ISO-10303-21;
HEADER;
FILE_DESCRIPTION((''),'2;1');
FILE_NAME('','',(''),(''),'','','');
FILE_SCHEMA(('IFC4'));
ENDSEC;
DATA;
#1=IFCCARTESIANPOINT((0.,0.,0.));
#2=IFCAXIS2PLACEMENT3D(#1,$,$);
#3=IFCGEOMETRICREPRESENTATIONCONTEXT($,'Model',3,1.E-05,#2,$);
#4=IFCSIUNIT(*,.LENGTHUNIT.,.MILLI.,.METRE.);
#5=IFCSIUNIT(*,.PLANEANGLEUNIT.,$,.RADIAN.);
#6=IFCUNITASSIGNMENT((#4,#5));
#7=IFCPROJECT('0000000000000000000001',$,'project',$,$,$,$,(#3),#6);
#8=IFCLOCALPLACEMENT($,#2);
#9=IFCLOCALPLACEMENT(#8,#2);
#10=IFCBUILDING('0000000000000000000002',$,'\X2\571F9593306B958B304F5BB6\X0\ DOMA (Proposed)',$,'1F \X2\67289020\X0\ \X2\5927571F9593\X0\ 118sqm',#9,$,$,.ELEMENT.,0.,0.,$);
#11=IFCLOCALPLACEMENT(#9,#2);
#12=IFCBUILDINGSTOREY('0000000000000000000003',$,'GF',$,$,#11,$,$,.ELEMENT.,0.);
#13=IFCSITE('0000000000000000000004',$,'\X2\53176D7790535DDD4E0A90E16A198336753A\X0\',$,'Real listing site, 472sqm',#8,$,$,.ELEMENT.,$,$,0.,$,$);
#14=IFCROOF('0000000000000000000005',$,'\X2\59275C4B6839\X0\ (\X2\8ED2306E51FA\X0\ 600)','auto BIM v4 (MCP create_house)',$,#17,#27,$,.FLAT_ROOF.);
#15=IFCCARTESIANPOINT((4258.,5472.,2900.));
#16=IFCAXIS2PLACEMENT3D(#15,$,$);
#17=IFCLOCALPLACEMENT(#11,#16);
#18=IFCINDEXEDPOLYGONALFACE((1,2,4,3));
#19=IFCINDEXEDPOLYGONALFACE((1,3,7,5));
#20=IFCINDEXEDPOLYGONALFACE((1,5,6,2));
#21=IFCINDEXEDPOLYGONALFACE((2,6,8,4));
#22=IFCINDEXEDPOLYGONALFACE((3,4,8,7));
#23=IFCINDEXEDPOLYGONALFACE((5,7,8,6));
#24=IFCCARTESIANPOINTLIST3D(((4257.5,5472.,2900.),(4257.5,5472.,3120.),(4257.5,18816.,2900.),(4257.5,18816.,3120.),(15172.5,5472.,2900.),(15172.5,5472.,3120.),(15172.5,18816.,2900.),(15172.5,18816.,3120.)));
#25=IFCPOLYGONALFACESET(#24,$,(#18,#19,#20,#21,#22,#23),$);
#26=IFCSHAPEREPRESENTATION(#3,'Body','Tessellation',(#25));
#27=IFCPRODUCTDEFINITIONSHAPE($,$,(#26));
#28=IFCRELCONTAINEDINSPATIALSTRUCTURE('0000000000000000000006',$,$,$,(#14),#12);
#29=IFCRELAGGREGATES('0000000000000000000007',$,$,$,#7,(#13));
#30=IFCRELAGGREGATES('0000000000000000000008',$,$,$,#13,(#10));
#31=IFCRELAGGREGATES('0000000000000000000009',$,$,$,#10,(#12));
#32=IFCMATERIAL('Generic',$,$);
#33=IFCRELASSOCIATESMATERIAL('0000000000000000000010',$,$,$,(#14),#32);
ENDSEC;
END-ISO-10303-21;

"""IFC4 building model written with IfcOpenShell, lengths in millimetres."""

from ifc_helpers import new_model, si_unit, frame, frame_2d, origin, place, context, project, spatial, rectangle, extrude, material, element, save


model = new_model("IFC4")

# Units and contexts
model_context = context("Model", 3, precision=1e-05, world=origin())
ifc_project = project(units=[si_unit("LENGTHUNIT", "METRE", prefix="MILLI"), si_unit("PLANEANGLEUNIT", "RADIAN")], contexts=[model_context])

# Site, building, storey
site_placement = place(None, origin())
site = spatial("IfcSite", under=ifc_project, at=site_placement, Name="北海道川上郡標茶町", ObjectType="Real listing site, 472sqm", CompositionType="ELEMENT", RefElevation=0.0)
building_placement = place(site_placement, origin())
building = spatial("IfcBuilding", under=site, at=building_placement, Name="土間に開く家 DOMA (Proposed)", ObjectType="1F 木造 大土間 118sqm", CompositionType="ELEMENT", ElevationOfRefHeight=0.0, ElevationOfTerrain=0.0)
storey_placement = place(building_placement, origin())
storey = spatial("IfcBuildingStorey", under=building, at=storey_placement, Name="GF", CompositionType="ELEMENT", Elevation=0.0)

# Shared definitions
ifc_material = material(Name="Generic")

# Roof
roof_placement = place(storey_placement, frame((4258.0, 5472.0, 2900.0)))
element("IfcRoof", 1, at=roof_placement, inside=storey, material=ifc_material, Name="大屋根 (軒の出 600)", Description="auto BIM v4 (MCP create_house)", PredefinedType="FLAT_ROOF", context=model_context, shape_type="SweptSolid", body=[
    extrude(rectangle(XDim=10915.0, YDim=13344.0, at=frame_2d((5457.0, 6672.0))), frame((4258.0, 5472.0, 2900.0)), (0.0, 0.0, 1.0), 220.0),
])

save(model, "model.ifc")
